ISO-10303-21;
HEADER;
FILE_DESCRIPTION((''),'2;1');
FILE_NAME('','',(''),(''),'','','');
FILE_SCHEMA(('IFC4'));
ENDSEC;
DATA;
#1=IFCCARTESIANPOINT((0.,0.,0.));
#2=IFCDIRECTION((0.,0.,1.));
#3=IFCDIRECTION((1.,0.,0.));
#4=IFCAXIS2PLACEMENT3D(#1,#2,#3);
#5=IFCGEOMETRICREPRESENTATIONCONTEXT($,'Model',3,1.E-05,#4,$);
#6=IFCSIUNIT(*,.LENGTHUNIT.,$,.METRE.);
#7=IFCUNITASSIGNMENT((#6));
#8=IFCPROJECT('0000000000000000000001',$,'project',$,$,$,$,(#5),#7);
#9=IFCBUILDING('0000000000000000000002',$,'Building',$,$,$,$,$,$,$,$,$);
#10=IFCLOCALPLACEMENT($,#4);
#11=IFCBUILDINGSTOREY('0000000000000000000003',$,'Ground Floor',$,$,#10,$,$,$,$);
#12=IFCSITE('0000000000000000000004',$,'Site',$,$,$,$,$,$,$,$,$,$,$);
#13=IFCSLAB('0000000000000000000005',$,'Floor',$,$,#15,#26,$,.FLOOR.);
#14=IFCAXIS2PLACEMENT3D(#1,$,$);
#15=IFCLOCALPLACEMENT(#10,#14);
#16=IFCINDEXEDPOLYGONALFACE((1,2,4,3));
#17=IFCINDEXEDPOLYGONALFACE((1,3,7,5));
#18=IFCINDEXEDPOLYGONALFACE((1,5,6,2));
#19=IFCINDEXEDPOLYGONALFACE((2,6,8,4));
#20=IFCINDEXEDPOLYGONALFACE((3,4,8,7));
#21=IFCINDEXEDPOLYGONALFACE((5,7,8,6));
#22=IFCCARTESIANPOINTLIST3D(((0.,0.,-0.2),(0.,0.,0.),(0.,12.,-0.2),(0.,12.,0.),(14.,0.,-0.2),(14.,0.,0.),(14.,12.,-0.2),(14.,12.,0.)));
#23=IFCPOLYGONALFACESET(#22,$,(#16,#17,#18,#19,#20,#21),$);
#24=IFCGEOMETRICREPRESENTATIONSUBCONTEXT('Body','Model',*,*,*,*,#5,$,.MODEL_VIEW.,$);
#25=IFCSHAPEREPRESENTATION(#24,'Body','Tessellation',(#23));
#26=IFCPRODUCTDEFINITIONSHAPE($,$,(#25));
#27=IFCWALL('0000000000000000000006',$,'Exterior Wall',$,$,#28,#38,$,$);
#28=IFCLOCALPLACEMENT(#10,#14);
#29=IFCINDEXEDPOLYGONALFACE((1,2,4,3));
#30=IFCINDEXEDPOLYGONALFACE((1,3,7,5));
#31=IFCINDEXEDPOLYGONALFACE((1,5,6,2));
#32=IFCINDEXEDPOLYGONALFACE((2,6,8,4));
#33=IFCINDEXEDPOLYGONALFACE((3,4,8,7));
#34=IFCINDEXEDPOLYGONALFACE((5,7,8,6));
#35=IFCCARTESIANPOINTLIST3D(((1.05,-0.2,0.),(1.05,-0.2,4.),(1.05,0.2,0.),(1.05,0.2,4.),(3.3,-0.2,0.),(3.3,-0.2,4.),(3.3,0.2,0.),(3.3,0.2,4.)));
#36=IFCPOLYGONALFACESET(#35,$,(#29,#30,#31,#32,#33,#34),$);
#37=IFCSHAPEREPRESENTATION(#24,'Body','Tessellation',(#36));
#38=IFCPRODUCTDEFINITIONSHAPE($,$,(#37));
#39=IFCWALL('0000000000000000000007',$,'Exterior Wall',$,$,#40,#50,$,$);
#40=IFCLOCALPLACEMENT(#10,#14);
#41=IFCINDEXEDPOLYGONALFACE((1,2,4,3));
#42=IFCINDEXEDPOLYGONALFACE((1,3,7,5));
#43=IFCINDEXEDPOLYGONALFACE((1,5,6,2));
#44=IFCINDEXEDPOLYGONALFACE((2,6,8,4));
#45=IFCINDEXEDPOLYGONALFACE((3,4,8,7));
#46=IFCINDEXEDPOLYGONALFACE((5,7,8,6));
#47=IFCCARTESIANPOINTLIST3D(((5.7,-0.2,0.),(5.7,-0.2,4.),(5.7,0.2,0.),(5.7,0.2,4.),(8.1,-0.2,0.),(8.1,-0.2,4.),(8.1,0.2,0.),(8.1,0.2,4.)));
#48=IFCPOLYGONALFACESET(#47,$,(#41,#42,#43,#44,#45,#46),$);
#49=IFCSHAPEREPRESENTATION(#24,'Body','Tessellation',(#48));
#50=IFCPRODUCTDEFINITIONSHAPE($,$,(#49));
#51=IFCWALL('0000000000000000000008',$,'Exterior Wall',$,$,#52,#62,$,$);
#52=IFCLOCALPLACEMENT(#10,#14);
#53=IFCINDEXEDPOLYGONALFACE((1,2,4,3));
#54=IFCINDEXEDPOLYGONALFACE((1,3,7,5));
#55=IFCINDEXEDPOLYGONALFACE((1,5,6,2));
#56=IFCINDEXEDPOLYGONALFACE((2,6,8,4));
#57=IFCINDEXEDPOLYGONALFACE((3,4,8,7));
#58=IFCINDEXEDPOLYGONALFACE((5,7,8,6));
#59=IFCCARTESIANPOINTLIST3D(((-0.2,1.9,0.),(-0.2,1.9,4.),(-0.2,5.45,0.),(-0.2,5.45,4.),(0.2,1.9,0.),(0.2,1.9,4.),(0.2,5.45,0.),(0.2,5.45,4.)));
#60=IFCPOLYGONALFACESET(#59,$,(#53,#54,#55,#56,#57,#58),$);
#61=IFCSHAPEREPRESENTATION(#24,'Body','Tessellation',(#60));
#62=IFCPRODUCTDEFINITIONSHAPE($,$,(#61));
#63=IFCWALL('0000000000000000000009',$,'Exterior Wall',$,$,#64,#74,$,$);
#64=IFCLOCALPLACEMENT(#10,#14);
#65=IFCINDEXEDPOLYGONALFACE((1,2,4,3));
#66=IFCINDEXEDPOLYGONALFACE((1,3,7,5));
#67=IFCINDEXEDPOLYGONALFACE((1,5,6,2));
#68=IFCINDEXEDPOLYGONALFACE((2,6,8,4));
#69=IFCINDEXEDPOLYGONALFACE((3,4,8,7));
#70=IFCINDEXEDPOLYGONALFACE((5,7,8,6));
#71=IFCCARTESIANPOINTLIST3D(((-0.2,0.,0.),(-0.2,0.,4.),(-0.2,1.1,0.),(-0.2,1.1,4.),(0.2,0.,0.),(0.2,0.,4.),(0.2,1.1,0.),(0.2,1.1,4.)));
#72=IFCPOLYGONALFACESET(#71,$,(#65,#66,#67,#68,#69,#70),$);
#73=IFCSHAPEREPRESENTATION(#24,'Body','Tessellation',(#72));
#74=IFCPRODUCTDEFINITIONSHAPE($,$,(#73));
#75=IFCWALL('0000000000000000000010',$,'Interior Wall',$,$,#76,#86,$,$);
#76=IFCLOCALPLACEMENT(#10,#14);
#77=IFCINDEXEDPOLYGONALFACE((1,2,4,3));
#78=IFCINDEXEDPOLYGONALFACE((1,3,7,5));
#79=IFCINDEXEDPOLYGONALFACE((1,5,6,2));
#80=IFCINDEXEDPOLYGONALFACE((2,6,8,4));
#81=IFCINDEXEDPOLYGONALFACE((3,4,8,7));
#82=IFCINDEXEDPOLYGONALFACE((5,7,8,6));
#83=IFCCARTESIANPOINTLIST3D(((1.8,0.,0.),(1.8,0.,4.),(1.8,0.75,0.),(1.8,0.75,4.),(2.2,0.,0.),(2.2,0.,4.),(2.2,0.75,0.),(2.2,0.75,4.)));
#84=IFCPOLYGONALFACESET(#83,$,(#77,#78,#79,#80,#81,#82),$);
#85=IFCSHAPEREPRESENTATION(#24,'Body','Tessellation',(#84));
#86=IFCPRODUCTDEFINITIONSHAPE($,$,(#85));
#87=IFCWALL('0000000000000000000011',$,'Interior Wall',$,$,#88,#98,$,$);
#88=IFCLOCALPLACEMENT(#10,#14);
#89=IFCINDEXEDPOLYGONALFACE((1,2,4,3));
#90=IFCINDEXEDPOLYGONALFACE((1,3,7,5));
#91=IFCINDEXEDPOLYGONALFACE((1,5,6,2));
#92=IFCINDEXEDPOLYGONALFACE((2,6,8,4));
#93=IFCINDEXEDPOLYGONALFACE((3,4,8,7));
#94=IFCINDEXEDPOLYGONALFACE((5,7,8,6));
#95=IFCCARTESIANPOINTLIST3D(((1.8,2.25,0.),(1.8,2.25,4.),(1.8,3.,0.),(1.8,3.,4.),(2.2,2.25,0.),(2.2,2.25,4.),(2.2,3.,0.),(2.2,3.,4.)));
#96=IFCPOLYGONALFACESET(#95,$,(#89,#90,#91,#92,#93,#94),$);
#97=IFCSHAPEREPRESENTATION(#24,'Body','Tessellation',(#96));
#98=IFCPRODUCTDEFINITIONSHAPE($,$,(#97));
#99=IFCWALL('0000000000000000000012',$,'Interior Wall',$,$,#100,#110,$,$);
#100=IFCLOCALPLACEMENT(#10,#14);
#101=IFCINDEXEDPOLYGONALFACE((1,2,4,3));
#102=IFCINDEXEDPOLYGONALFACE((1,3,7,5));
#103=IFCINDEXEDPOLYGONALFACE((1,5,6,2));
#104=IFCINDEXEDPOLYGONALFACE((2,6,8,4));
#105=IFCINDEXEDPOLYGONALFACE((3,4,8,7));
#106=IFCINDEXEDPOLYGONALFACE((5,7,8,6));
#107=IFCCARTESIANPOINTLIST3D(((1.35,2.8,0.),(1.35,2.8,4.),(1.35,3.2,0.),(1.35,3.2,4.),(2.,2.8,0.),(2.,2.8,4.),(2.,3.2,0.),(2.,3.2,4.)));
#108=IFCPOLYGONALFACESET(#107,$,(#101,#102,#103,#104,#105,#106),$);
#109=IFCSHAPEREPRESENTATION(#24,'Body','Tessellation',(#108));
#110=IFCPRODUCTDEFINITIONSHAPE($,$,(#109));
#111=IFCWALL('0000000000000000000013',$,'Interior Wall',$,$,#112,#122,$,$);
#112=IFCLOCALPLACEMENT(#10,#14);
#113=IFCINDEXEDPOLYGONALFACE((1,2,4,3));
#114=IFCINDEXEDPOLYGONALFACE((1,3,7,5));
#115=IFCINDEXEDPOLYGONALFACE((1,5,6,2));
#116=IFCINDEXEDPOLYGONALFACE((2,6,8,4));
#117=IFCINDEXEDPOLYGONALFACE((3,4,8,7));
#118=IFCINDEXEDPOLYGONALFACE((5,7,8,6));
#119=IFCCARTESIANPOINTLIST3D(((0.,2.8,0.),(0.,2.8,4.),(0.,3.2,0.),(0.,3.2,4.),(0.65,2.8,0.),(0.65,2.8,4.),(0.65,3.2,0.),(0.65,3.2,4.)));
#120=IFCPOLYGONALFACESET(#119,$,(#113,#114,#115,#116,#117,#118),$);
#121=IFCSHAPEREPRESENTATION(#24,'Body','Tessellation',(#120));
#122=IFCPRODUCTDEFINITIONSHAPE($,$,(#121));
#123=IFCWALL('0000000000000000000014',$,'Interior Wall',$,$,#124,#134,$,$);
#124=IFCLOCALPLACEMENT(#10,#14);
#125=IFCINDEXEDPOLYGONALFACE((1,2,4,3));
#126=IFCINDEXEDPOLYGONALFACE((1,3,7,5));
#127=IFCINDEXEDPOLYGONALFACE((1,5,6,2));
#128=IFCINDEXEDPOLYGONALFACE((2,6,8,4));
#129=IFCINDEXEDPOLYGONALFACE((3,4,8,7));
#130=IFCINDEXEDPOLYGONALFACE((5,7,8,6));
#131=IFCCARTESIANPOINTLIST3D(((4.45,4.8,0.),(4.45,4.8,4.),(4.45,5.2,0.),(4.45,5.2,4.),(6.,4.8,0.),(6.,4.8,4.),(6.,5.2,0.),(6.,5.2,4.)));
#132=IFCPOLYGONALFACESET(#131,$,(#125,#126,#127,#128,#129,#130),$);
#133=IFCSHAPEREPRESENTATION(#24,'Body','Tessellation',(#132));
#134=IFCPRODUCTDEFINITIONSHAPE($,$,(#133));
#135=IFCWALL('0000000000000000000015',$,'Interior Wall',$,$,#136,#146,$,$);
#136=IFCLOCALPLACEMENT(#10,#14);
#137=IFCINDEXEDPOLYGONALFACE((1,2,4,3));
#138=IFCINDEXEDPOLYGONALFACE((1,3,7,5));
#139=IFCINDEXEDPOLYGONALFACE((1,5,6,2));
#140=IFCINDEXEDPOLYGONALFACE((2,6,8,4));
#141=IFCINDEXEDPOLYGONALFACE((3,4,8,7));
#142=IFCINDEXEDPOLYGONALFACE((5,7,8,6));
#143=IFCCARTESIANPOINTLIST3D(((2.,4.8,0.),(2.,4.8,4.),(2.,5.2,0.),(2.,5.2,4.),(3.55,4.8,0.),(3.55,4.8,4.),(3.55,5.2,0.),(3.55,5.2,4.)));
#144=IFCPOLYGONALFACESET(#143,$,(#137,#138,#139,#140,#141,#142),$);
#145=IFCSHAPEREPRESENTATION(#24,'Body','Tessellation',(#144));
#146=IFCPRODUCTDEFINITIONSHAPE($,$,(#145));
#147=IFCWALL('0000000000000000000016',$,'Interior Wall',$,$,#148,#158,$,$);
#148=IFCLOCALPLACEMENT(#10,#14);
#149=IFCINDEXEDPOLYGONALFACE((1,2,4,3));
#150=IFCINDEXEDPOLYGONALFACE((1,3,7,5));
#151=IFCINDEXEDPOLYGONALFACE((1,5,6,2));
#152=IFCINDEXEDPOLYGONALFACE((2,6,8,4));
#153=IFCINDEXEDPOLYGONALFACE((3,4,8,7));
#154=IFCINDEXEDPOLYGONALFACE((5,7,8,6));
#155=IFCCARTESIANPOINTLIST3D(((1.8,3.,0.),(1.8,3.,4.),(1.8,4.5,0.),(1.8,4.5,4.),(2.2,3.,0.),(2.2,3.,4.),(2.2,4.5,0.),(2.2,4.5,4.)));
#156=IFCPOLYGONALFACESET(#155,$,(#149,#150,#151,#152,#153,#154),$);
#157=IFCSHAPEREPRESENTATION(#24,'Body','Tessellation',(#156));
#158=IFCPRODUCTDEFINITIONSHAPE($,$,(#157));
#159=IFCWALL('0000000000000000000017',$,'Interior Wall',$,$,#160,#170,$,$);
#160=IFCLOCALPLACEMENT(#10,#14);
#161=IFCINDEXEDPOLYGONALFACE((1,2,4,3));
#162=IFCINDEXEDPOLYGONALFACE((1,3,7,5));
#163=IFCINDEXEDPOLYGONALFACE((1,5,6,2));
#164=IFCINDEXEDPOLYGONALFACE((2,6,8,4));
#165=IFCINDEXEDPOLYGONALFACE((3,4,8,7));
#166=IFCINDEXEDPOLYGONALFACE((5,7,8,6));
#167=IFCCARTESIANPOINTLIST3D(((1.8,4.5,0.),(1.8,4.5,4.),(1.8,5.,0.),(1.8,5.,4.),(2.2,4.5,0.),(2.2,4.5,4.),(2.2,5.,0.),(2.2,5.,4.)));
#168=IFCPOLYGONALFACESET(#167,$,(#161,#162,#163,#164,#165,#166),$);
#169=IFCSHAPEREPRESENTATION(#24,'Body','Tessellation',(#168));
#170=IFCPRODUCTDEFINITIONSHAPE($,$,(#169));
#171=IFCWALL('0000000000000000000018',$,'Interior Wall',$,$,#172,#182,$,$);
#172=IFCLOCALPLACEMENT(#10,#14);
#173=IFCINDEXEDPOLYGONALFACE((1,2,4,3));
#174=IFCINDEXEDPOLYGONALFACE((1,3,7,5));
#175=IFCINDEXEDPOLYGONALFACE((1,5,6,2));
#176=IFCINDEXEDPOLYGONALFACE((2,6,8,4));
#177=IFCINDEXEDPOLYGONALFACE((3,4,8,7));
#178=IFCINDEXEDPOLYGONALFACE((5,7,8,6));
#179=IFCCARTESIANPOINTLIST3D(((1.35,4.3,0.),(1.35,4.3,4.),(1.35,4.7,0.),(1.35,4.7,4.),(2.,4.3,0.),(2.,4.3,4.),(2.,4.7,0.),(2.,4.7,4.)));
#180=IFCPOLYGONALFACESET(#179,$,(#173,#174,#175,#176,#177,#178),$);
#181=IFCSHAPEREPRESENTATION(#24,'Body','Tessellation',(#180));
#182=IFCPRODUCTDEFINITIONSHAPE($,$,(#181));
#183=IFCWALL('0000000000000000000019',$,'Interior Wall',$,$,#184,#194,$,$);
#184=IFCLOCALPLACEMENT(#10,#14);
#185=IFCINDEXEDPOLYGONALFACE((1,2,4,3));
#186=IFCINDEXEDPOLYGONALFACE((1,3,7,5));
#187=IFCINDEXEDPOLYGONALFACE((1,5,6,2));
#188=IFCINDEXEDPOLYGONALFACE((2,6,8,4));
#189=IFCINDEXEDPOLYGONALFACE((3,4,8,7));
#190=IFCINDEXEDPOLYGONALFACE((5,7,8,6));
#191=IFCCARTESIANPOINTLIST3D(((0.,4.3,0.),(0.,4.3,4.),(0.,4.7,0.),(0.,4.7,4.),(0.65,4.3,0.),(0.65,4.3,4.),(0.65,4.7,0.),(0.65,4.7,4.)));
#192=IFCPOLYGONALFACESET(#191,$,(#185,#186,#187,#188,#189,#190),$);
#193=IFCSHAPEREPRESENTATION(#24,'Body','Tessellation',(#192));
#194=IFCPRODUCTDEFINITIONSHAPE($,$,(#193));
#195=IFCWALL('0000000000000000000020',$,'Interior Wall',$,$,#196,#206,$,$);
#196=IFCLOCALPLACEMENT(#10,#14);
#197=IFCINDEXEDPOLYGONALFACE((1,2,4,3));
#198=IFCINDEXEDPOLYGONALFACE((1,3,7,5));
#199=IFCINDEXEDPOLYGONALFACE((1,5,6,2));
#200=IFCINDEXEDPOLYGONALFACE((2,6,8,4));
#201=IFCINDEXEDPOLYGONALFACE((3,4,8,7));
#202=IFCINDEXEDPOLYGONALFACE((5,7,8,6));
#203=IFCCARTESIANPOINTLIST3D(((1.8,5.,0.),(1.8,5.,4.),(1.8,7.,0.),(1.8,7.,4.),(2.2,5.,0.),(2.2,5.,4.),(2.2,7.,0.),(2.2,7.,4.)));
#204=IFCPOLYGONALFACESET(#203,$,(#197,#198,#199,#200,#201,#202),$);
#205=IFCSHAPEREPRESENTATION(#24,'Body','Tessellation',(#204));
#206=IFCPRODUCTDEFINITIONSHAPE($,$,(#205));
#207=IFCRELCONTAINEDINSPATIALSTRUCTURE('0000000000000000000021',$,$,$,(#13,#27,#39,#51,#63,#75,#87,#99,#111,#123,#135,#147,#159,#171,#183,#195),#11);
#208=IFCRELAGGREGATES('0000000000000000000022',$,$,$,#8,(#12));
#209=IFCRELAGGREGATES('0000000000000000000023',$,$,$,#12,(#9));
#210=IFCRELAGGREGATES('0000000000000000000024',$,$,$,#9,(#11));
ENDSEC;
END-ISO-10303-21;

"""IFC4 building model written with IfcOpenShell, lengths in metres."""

from ifc_helpers import new_model, si_unit, frame, origin_with_axes, place, context, subcontext, project, spatial, indexed_curve, outline, extrude, element, save


model = new_model("IFC4")

# Units and contexts
model_context = context("Model", 3, precision=1e-05, world=origin_with_axes())
body_context = subcontext(model_context, "Body", "Model", "MODEL_VIEW")
ifc_project = project(units=[si_unit("LENGTHUNIT", "METRE")], contexts=[model_context])

# Site, building, storey
site = spatial("IfcSite", under=ifc_project, Name="Site")
building = spatial("IfcBuilding", under=site, Name="Building")
storey_placement = place(None, origin_with_axes())
storey = spatial("IfcBuildingStorey", under=building, at=storey_placement, Name="Ground Floor")

# Slab
slab_placement = place(storey_placement, frame((0.0, 0.0, -0.2), z_axis=(0.0, 0.0, 1.0), x_axis=(1.0, 0.0, 0.0)))
element("IfcSlab", 1, at=slab_placement, inside=storey, Name="Floor", PredefinedType="FLOOR", context=body_context, shape_type="SweptSolid", body=[
    extrude(outline(indexed_curve([(0.0, 0.0), (14.0, 0.0), (14.0, 12.0), (0.0, 12.0)])), None, (0.0, 0.0, 1.0), 0.2),
])

# Walls
wall_1_placement = place(storey_placement, frame((1.05, 0.0, 0.0), z_axis=(0.0, 0.0, 1.0), x_axis=(1.0, 0.0, 0.0)))
element("IfcWall", 2, at=wall_1_placement, inside=storey, Name="Exterior Wall", context=body_context, shape_type="SweptSolid", body=[
    extrude(outline(indexed_curve([(0.0, 0.0), (0.0, 0.4), (2.25, 0.4), (2.25, 0.0), (0.0, 0.0)], self_intersect=False)), frame((0.0, -0.2, 0.0), z_axis=(0.0, 0.0, 1.0), x_axis=(1.0, 0.0, 0.0)), (0.0, 0.0, 1.0), 4.0),
])
wall_2_placement = place(storey_placement, frame((5.7, 0.0, 0.0), z_axis=(0.0, 0.0, 1.0), x_axis=(1.0, 0.0, 0.0)))
element("IfcWall", 3, at=wall_2_placement, inside=storey, Name="Exterior Wall", context=body_context, shape_type="SweptSolid", body=[
    extrude(outline(indexed_curve([(0.0, 0.0), (0.0, 0.4), (2.4, 0.4), (2.4, 0.0), (0.0, 0.0)], self_intersect=False)), frame((0.0, -0.2, 0.0), z_axis=(0.0, 0.0, 1.0), x_axis=(1.0, 0.0, 0.0)), (0.0, 0.0, 1.0), 4.0),
])
wall_3_placement = place(storey_placement, frame((0.0, 5.45, 0.0), z_axis=(0.0, 0.0, 1.0), x_axis=(0.0, -1.0, 0.0)))
element("IfcWall", 4, at=wall_3_placement, inside=storey, Name="Exterior Wall", context=body_context, shape_type="SweptSolid", body=[
    extrude(outline(indexed_curve([(0.0, 0.0), (0.0, 0.4), (3.55, 0.4), (3.55, 0.0), (0.0, 0.0)], self_intersect=False)), frame((0.0, -0.2, 0.0), z_axis=(0.0, 0.0, 1.0), x_axis=(1.0, 0.0, 0.0)), (0.0, 0.0, 1.0), 4.0),
])
wall_4_placement = place(storey_placement, frame((0.0, 1.1, 0.0), z_axis=(0.0, 0.0, 1.0), x_axis=(0.0, -1.0, 0.0)))
element("IfcWall", 5, at=wall_4_placement, inside=storey, Name="Exterior Wall", context=body_context, shape_type="SweptSolid", body=[
    extrude(outline(indexed_curve([(0.0, 0.0), (0.0, 0.4), (1.1, 0.4), (1.1, 0.0), (0.0, 0.0)], self_intersect=False)), frame((0.0, -0.2, 0.0), z_axis=(0.0, 0.0, 1.0), x_axis=(1.0, 0.0, 0.0)), (0.0, 0.0, 1.0), 4.0),
])
for number, where, z_axis, x_axis, name in (
    (6, (2.0, 0.0, 0.0), (0.0, 0.0, 1.0), (0.0, 1.0, 0.0), "Interior Wall"),
    (7, (2.0, 2.25, 0.0), (0.0, 0.0, 1.0), (0.0, 1.0, 0.0), "Interior Wall"),
):
    element("IfcWall", number, at=place(storey_placement, frame(where, z_axis=z_axis, x_axis=x_axis)), inside=storey, Name=name, context=body_context, shape_type="SweptSolid", body=[
        extrude(outline(indexed_curve([(0.0, 0.0), (0.0, 0.4), (0.75, 0.4), (0.75, 0.0), (0.0, 0.0)], self_intersect=False)), frame((0.0, -0.2, 0.0), z_axis=(0.0, 0.0, 1.0), x_axis=(1.0, 0.0, 0.0)), (0.0, 0.0, 1.0), 4.0),
    ])
for number, where, z_axis, x_axis, name in (
    (8, (2.0, 3.0, 0.0), (0.0, 0.0, 1.0), (-1.0, 0.0, 0.0), "Interior Wall"),
    (9, (0.65, 3.0, 0.0), (0.0, 0.0, 1.0), (-1.0, 0.0, 0.0), "Interior Wall"),
):
    element("IfcWall", number, at=place(storey_placement, frame(where, z_axis=z_axis, x_axis=x_axis)), inside=storey, Name=name, context=body_context, shape_type="SweptSolid", body=[
        extrude(outline(indexed_curve([(0.0, 0.0), (0.0, 0.4), (0.65, 0.4), (0.65, 0.0), (0.0, 0.0)], self_intersect=False)), frame((0.0, -0.2, 0.0), z_axis=(0.0, 0.0, 1.0), x_axis=(1.0, 0.0, 0.0)), (0.0, 0.0, 1.0), 4.0),
    ])
for number, where, z_axis, x_axis, name in (
    (10, (6.0, 5.0, 0.0), (0.0, 0.0, 1.0), (-1.0, 0.0, 0.0), "Interior Wall"),
    (11, (3.55, 5.0, 0.0), (0.0, 0.0, 1.0), (-1.0, 0.0, 0.0), "Interior Wall"),
):
    element("IfcWall", number, at=place(storey_placement, frame(where, z_axis=z_axis, x_axis=x_axis)), inside=storey, Name=name, context=body_context, shape_type="SweptSolid", body=[
        extrude(outline(indexed_curve([(0.0, 0.0), (0.0, 0.4), (1.55, 0.4), (1.55, 0.0), (0.0, 0.0)], self_intersect=False)), frame((0.0, -0.2, 0.0), z_axis=(0.0, 0.0, 1.0), x_axis=(1.0, 0.0, 0.0)), (0.0, 0.0, 1.0), 4.0),
    ])
wall_5_placement = place(storey_placement, frame((2.0, 4.5, 0.0), z_axis=(0.0, 0.0, 1.0), x_axis=(0.0, -1.0, 0.0)))
element("IfcWall", 12, at=wall_5_placement, inside=storey, Name="Interior Wall", context=body_context, shape_type="SweptSolid", body=[
    extrude(outline(indexed_curve([(0.0, 0.0), (0.0, 0.4), (1.5, 0.4), (1.5, 0.0), (0.0, 0.0)], self_intersect=False)), frame((0.0, -0.2, 0.0), z_axis=(0.0, 0.0, 1.0), x_axis=(1.0, 0.0, 0.0)), (0.0, 0.0, 1.0), 4.0),
])
wall_6_placement = place(storey_placement, frame((2.0, 5.0, 0.0), z_axis=(0.0, 0.0, 1.0), x_axis=(0.0, -1.0, 0.0)))
element("IfcWall", 13, at=wall_6_placement, inside=storey, Name="Interior Wall", context=body_context, shape_type="SweptSolid", body=[
    extrude(outline(indexed_curve([(0.0, 0.0), (0.0, 0.4), (0.5, 0.4), (0.5, 0.0), (0.0, 0.0)], self_intersect=False)), frame((0.0, -0.2, 0.0), z_axis=(0.0, 0.0, 1.0), x_axis=(1.0, 0.0, 0.0)), (0.0, 0.0, 1.0), 4.0),
])
for number, where, z_axis, x_axis, name in (
    (14, (2.0, 4.5, 0.0), (0.0, 0.0, 1.0), (-1.0, 0.0, 0.0), "Interior Wall"),
    (15, (0.65, 4.5, 0.0), (0.0, 0.0, 1.0), (-1.0, 0.0, 0.0), "Interior Wall"),
):
    element("IfcWall", number, at=place(storey_placement, frame(where, z_axis=z_axis, x_axis=x_axis)), inside=storey, Name=name, context=body_context, shape_type="SweptSolid", body=[
        extrude(outline(indexed_curve([(0.0, 0.0), (0.0, 0.4), (0.65, 0.4), (0.65, 0.0), (0.0, 0.0)], self_intersect=False)), frame((0.0, -0.2, 0.0), z_axis=(0.0, 0.0, 1.0), x_axis=(1.0, 0.0, 0.0)), (0.0, 0.0, 1.0), 4.0),
    ])
wall_7_placement = place(storey_placement, frame((2.0, 5.0, 0.0), z_axis=(0.0, 0.0, 1.0), x_axis=(0.0, 1.0, 0.0)))
element("IfcWall", 16, at=wall_7_placement, inside=storey, Name="Interior Wall", context=body_context, shape_type="SweptSolid", body=[
    extrude(outline(indexed_curve([(0.0, 0.0), (0.0, 0.4), (2.0, 0.4), (2.0, 0.0), (0.0, 0.0)], self_intersect=False)), frame((0.0, -0.2, 0.0), z_axis=(0.0, 0.0, 1.0), x_axis=(1.0, 0.0, 0.0)), (0.0, 0.0, 1.0), 4.0),
])

save(model, "model.ifc")
